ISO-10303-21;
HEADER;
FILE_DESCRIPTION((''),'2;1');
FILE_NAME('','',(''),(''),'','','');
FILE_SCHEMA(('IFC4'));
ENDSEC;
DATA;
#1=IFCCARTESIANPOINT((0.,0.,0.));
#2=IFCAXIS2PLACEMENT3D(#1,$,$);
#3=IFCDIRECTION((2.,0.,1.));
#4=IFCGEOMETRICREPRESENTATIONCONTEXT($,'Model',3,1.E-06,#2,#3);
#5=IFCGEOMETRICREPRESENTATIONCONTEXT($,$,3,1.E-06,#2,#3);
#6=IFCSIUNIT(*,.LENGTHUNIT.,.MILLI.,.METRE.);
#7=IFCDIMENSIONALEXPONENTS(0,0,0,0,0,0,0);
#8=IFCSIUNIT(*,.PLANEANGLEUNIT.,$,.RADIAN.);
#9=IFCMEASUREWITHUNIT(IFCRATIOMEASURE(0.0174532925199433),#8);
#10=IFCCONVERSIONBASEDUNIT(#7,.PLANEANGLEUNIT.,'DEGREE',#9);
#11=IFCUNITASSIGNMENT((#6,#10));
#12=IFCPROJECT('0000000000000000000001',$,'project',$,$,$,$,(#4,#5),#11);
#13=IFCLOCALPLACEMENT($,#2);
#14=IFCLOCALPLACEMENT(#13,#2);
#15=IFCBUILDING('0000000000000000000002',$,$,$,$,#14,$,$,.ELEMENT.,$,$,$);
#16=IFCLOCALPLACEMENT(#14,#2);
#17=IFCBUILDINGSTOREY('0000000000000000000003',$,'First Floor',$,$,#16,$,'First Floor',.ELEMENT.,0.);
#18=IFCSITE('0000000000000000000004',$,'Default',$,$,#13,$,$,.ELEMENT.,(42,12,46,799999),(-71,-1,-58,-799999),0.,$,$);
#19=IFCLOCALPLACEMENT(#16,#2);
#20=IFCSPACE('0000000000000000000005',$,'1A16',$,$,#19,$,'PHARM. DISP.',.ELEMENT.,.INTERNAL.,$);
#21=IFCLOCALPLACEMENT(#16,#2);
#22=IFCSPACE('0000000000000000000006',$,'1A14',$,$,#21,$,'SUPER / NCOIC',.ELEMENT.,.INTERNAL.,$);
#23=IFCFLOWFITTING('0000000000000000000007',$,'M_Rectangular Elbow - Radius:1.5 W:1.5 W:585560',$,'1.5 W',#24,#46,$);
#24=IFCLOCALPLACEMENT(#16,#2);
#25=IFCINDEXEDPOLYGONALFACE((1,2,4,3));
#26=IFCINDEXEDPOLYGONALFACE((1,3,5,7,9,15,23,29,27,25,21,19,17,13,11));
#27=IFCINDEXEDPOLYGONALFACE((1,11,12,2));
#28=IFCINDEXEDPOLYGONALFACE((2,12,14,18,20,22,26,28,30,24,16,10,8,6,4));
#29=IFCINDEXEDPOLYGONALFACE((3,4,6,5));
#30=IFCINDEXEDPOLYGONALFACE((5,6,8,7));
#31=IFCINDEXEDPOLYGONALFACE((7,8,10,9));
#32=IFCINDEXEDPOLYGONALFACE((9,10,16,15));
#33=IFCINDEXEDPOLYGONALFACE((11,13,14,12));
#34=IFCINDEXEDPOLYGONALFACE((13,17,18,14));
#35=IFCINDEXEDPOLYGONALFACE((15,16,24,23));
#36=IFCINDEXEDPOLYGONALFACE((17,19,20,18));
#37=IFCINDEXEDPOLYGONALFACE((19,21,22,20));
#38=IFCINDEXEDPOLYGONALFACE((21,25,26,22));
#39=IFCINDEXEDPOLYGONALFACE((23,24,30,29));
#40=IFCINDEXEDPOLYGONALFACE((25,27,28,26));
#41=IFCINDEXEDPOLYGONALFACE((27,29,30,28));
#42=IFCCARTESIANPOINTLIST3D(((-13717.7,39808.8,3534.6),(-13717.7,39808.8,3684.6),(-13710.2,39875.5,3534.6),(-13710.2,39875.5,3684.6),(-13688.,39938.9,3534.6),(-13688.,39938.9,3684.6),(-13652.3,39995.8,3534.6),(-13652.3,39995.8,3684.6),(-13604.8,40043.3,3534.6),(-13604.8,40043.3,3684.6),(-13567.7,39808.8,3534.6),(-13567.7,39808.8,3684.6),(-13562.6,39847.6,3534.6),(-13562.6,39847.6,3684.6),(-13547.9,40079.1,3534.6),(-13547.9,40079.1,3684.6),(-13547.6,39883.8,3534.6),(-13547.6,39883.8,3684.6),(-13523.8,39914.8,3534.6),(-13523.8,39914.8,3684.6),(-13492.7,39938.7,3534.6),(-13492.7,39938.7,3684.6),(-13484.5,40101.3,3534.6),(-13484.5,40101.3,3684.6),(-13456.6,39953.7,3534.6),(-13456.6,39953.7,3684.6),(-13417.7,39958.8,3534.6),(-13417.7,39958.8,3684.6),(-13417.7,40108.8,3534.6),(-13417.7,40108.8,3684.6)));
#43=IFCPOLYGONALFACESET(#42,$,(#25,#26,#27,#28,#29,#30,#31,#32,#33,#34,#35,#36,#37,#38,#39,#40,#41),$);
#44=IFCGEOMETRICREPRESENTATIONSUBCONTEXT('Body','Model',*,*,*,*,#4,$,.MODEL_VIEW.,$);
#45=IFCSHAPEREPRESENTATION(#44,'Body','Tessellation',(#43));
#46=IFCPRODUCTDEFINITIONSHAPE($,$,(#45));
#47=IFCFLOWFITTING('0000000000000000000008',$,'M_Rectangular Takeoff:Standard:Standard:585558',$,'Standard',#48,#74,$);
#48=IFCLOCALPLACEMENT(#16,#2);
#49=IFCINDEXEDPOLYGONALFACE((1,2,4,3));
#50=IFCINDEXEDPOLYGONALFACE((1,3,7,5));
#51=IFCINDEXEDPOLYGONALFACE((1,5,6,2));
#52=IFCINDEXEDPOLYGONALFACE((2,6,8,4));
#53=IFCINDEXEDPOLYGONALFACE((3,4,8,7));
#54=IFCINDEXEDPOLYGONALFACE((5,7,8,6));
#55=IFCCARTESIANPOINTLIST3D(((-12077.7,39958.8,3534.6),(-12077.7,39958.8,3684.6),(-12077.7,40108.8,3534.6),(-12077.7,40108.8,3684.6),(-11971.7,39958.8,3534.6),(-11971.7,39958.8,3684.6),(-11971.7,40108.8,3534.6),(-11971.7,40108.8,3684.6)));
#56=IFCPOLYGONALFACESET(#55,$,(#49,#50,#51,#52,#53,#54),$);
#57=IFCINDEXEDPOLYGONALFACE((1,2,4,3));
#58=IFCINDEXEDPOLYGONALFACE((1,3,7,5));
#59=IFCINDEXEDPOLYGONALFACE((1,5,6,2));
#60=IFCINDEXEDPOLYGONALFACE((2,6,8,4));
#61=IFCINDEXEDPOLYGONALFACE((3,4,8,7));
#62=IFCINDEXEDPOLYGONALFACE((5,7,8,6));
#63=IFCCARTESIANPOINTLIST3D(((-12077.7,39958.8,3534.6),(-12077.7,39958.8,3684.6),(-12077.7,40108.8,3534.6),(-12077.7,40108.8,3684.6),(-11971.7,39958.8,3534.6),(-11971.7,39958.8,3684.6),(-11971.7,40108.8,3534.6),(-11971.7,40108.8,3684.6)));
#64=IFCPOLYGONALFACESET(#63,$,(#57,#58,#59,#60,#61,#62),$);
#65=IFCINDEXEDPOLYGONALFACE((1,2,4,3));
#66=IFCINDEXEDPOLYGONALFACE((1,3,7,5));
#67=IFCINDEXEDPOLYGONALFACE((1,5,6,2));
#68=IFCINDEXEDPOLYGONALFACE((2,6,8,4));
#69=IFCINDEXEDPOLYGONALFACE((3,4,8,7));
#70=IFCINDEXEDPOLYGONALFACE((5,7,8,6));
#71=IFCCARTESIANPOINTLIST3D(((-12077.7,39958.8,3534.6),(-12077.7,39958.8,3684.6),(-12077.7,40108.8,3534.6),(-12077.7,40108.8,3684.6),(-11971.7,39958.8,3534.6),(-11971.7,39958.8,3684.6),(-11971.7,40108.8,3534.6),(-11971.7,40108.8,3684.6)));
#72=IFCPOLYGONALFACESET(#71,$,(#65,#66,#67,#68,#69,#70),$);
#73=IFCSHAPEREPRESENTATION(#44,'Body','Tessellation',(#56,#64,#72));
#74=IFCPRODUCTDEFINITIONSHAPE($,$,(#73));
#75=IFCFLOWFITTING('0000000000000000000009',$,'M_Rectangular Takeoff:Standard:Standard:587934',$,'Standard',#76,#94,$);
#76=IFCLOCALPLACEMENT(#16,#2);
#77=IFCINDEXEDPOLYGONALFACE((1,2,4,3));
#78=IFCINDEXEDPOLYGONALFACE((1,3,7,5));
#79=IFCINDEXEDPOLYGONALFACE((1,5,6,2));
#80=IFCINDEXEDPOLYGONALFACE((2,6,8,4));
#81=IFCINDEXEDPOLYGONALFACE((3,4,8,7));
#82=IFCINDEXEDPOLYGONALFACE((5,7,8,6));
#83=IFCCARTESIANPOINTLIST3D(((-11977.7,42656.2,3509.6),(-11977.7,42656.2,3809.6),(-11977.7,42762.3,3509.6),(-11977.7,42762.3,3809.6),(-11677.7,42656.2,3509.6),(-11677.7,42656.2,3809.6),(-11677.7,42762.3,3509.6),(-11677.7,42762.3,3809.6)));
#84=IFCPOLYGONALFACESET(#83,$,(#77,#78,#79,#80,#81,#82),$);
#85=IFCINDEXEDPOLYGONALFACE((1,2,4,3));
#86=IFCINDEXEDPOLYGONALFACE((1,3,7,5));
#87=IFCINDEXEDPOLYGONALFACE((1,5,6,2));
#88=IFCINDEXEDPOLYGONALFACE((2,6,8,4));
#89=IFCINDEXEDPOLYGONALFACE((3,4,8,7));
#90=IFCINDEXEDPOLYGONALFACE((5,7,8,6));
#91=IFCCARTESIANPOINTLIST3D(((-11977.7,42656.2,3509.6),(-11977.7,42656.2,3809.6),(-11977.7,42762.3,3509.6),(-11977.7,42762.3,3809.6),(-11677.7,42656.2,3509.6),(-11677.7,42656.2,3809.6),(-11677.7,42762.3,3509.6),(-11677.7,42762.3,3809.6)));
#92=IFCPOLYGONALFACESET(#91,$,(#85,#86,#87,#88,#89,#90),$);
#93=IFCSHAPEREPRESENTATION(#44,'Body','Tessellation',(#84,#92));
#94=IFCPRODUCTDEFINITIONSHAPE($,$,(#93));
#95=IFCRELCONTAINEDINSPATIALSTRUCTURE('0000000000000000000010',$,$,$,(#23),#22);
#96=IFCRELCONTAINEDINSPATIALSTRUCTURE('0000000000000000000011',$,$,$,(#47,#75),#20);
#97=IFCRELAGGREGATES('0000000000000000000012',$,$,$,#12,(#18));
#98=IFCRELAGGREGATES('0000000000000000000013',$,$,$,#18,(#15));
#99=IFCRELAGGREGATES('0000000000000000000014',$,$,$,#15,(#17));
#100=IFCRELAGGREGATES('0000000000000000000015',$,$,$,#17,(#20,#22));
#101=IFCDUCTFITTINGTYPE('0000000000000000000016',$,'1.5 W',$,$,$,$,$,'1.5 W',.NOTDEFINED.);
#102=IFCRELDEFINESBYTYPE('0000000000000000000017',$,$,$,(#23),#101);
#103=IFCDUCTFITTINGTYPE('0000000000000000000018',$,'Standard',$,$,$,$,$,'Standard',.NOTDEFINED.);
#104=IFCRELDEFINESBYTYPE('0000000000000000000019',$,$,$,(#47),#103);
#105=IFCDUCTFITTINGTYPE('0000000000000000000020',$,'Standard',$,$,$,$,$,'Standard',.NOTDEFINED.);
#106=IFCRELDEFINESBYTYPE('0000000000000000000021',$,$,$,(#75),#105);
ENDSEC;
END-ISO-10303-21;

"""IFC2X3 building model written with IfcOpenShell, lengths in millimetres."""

from ifc_helpers import new_model, entity, si_unit, converted_unit, direction, frame, frame_2d, origin, place, context, subcontext, project, spatial, polyline, circle_curve, parameter, trimmed, segment, composite_curve, rectangle, outline, extrude, source, transform, mapped, type_object, type_shapes, element, save


model = new_model("IFC2X3")

# Units and contexts
model_context = context("Model", 3, precision=1e-06, world=origin(), true_north=direction((2.0, 0.0, 1.0)))
context_of_model = context(None, 3, precision=1e-06, world=origin(), true_north=direction((2.0, 0.0, 1.0)))
body_context = subcontext(model_context, "Body", "Model", "MODEL_VIEW")
ifc_project = project(units=[si_unit("LENGTHUNIT", "METRE", prefix="MILLI"), converted_unit("PLANEANGLEUNIT", "DEGREE", entity("IfcRatioMeasure", 0.0174532925199433), si_unit("PLANEANGLEUNIT", "RADIAN"), dimensions=[0, 0, 0, 0, 0, 0, 0])], contexts=[model_context, context_of_model])

# Site, building, storey, space
site_placement = place(None, origin())
site = spatial("IfcSite", under=ifc_project, at=site_placement, Name="Default", CompositionType="ELEMENT", RefLatitude=(42, 12, 46, 799999), RefLongitude=(-71, -1, -58, -799999), RefElevation=0.0)
building_placement = place(site_placement, origin())
building = spatial("IfcBuilding", under=site, at=building_placement, CompositionType="ELEMENT")
storey_placement = place(building_placement, origin())
storey = spatial("IfcBuildingStorey", under=building, at=storey_placement, Name="First Floor", LongName="First Floor", CompositionType="ELEMENT", Elevation=0.0)
space_1_placement = place(storey_placement, origin())
space_1 = spatial("IfcSpace", under=storey, at=space_1_placement, Name="1A16", LongName="PHARM. DISP.", CompositionType="ELEMENT", InteriorOrExteriorSpace="INTERNAL")

# Shared definitions
space_2_placement = place(storey_placement, origin())
space_2 = spatial("IfcSpace", under=storey, at=space_2_placement, Name="1A14", LongName="SUPER / NCOIC", CompositionType="ELEMENT", InteriorOrExteriorSpace="INTERNAL")

# Flow fittings
duct_fitting_type_1 = type_object("IfcDuctFittingType", Name="1.5 W", ElementType="1.5 W", PredefinedType="NOTDEFINED")
shared_shape_1 = source(origin(), body_context, "Body", "SweptSolid", [
    extrude(outline(composite_curve([segment(polyline([(-187.5, -112.5), (-37.5, -112.5)]), True, "CONTINUOUS"), segment(trimmed(circle_curve(frame_2d((112.5, -112.5), x_axis=(0.0, 1.0)), 150.0), [parameter(0.0)], [parameter(90.0)], True, "PARAMETER"), False, "CONTINUOUS"), segment(polyline([(112.5, 37.5), (112.5, 187.5)]), True, "CONTINUOUS"), segment(trimmed(circle_curve(frame_2d((112.5, -112.5), x_axis=(0.0, 1.0)), 300.0), [parameter(0.0)], [parameter(90.0)], True, "PARAMETER"), True, "CONTINUOUS")], self_intersect=False)), frame((-112.5, 112.5, -75.0), z_axis=(0.0, 0.0, 1.0), x_axis=(-1.0, 0.0, 0.0)), (0.0, 0.0, 1.0), 150.0),
])
type_shapes(duct_fitting_type_1, [shared_shape_1])
flow_fitting_1_placement = place(space_2_placement, frame((-13642.7, 40033.8, 3609.6), z_axis=(0.0, 0.0, 1.0), x_axis=(-1.0, 0.0, 0.0)))
element("IfcFlowFitting", 1, at=flow_fitting_1_placement, inside=space_2, type_object=duct_fitting_type_1, Name="M_Rectangular Elbow - Radius:1.5 W:1.5 W:585560", ObjectType="1.5 W", context=body_context, shape_type="MappedRepresentation", body=[
    mapped(shared_shape_1, transform((0.0, 0.0, 0.0), scale=1.0)),
])
duct_fitting_type_2 = type_object("IfcDuctFittingType", Name="Standard", ElementType="Standard", PredefinedType="NOTDEFINED")
shared_shape_2 = source(origin(), body_context, "Body", "SweptSolid", [
    extrude(rectangle(XDim=150.0, YDim=106.1, at=frame_2d((0.0, 0.0), x_axis=(1.0, 0.0))), frame((47.0, 0.0, -75.0), z_axis=(0.0, 0.0, 1.0), x_axis=(0.0, -1.0, 0.0)), (0.0, 0.0, 1.0), 150.0),
    extrude(rectangle(XDim=150.0, YDim=106.1, at=frame_2d((0.0, 0.0), x_axis=(1.0, 0.0))), frame((47.0, 0.0, -75.0), z_axis=(0.0, 0.0, 1.0), x_axis=(0.0, -1.0, 0.0)), (0.0, 0.0, 1.0), 150.0),
    extrude(rectangle(XDim=150.0, YDim=106.1, at=frame_2d((0.0, 0.0), x_axis=(1.0, 0.0))), frame((47.0, 0.0, -75.0), z_axis=(0.0, 0.0, 1.0), x_axis=(0.0, -1.0, 0.0)), (0.0, 0.0, 1.0), 150.0),
])
type_shapes(duct_fitting_type_2, [shared_shape_2])
flow_fitting_2_placement = place(space_1_placement, frame((-11977.7, 40033.8, 3609.6), z_axis=(0.0, 0.0, -1.0), x_axis=(-1.0, 0.0, 0.0)))
element("IfcFlowFitting", 2, at=flow_fitting_2_placement, inside=space_1, type_object=duct_fitting_type_2, Name="M_Rectangular Takeoff:Standard:Standard:585558", ObjectType="Standard", context=body_context, shape_type="MappedRepresentation", body=[
    mapped(shared_shape_2, transform((0.0, 0.0, 0.0), scale=1.0)),
])
duct_fitting_type_3 = type_object("IfcDuctFittingType", Name="Standard", ElementType="Standard", PredefinedType="NOTDEFINED")
shared_shape_3 = source(origin(), body_context, "Body", "SweptSolid", [
    extrude(rectangle(XDim=300.0, YDim=106.1, at=frame_2d((0.0, 0.0), x_axis=(1.0, 0.0))), frame((47.0, 0.0, -150.0), z_axis=(0.0, 0.0, 1.0), x_axis=(0.0, -1.0, 0.0)), (0.0, 0.0, 1.0), 300.0),
    extrude(rectangle(XDim=300.0, YDim=106.1, at=frame_2d((0.0, 0.0), x_axis=(1.0, 0.0))), frame((47.0, 0.0, -150.0), z_axis=(0.0, 0.0, 1.0), x_axis=(0.0, -1.0, 0.0)), (0.0, 0.0, 1.0), 300.0),
])
type_shapes(duct_fitting_type_3, [shared_shape_3])
flow_fitting_3_placement = place(space_1_placement, frame((-11827.7, 42756.2, 3659.6), z_axis=(0.0, 0.0, -1.0), x_axis=(0.0, -1.0, 0.0)))
element("IfcFlowFitting", 3, at=flow_fitting_3_placement, inside=space_1, type_object=duct_fitting_type_3, Name="M_Rectangular Takeoff:Standard:Standard:587934", ObjectType="Standard", context=body_context, shape_type="MappedRepresentation", body=[
    mapped(shared_shape_3, transform((0.0, 0.0, 0.0), scale=1.0)),
])

save(model, "model.ifc")
